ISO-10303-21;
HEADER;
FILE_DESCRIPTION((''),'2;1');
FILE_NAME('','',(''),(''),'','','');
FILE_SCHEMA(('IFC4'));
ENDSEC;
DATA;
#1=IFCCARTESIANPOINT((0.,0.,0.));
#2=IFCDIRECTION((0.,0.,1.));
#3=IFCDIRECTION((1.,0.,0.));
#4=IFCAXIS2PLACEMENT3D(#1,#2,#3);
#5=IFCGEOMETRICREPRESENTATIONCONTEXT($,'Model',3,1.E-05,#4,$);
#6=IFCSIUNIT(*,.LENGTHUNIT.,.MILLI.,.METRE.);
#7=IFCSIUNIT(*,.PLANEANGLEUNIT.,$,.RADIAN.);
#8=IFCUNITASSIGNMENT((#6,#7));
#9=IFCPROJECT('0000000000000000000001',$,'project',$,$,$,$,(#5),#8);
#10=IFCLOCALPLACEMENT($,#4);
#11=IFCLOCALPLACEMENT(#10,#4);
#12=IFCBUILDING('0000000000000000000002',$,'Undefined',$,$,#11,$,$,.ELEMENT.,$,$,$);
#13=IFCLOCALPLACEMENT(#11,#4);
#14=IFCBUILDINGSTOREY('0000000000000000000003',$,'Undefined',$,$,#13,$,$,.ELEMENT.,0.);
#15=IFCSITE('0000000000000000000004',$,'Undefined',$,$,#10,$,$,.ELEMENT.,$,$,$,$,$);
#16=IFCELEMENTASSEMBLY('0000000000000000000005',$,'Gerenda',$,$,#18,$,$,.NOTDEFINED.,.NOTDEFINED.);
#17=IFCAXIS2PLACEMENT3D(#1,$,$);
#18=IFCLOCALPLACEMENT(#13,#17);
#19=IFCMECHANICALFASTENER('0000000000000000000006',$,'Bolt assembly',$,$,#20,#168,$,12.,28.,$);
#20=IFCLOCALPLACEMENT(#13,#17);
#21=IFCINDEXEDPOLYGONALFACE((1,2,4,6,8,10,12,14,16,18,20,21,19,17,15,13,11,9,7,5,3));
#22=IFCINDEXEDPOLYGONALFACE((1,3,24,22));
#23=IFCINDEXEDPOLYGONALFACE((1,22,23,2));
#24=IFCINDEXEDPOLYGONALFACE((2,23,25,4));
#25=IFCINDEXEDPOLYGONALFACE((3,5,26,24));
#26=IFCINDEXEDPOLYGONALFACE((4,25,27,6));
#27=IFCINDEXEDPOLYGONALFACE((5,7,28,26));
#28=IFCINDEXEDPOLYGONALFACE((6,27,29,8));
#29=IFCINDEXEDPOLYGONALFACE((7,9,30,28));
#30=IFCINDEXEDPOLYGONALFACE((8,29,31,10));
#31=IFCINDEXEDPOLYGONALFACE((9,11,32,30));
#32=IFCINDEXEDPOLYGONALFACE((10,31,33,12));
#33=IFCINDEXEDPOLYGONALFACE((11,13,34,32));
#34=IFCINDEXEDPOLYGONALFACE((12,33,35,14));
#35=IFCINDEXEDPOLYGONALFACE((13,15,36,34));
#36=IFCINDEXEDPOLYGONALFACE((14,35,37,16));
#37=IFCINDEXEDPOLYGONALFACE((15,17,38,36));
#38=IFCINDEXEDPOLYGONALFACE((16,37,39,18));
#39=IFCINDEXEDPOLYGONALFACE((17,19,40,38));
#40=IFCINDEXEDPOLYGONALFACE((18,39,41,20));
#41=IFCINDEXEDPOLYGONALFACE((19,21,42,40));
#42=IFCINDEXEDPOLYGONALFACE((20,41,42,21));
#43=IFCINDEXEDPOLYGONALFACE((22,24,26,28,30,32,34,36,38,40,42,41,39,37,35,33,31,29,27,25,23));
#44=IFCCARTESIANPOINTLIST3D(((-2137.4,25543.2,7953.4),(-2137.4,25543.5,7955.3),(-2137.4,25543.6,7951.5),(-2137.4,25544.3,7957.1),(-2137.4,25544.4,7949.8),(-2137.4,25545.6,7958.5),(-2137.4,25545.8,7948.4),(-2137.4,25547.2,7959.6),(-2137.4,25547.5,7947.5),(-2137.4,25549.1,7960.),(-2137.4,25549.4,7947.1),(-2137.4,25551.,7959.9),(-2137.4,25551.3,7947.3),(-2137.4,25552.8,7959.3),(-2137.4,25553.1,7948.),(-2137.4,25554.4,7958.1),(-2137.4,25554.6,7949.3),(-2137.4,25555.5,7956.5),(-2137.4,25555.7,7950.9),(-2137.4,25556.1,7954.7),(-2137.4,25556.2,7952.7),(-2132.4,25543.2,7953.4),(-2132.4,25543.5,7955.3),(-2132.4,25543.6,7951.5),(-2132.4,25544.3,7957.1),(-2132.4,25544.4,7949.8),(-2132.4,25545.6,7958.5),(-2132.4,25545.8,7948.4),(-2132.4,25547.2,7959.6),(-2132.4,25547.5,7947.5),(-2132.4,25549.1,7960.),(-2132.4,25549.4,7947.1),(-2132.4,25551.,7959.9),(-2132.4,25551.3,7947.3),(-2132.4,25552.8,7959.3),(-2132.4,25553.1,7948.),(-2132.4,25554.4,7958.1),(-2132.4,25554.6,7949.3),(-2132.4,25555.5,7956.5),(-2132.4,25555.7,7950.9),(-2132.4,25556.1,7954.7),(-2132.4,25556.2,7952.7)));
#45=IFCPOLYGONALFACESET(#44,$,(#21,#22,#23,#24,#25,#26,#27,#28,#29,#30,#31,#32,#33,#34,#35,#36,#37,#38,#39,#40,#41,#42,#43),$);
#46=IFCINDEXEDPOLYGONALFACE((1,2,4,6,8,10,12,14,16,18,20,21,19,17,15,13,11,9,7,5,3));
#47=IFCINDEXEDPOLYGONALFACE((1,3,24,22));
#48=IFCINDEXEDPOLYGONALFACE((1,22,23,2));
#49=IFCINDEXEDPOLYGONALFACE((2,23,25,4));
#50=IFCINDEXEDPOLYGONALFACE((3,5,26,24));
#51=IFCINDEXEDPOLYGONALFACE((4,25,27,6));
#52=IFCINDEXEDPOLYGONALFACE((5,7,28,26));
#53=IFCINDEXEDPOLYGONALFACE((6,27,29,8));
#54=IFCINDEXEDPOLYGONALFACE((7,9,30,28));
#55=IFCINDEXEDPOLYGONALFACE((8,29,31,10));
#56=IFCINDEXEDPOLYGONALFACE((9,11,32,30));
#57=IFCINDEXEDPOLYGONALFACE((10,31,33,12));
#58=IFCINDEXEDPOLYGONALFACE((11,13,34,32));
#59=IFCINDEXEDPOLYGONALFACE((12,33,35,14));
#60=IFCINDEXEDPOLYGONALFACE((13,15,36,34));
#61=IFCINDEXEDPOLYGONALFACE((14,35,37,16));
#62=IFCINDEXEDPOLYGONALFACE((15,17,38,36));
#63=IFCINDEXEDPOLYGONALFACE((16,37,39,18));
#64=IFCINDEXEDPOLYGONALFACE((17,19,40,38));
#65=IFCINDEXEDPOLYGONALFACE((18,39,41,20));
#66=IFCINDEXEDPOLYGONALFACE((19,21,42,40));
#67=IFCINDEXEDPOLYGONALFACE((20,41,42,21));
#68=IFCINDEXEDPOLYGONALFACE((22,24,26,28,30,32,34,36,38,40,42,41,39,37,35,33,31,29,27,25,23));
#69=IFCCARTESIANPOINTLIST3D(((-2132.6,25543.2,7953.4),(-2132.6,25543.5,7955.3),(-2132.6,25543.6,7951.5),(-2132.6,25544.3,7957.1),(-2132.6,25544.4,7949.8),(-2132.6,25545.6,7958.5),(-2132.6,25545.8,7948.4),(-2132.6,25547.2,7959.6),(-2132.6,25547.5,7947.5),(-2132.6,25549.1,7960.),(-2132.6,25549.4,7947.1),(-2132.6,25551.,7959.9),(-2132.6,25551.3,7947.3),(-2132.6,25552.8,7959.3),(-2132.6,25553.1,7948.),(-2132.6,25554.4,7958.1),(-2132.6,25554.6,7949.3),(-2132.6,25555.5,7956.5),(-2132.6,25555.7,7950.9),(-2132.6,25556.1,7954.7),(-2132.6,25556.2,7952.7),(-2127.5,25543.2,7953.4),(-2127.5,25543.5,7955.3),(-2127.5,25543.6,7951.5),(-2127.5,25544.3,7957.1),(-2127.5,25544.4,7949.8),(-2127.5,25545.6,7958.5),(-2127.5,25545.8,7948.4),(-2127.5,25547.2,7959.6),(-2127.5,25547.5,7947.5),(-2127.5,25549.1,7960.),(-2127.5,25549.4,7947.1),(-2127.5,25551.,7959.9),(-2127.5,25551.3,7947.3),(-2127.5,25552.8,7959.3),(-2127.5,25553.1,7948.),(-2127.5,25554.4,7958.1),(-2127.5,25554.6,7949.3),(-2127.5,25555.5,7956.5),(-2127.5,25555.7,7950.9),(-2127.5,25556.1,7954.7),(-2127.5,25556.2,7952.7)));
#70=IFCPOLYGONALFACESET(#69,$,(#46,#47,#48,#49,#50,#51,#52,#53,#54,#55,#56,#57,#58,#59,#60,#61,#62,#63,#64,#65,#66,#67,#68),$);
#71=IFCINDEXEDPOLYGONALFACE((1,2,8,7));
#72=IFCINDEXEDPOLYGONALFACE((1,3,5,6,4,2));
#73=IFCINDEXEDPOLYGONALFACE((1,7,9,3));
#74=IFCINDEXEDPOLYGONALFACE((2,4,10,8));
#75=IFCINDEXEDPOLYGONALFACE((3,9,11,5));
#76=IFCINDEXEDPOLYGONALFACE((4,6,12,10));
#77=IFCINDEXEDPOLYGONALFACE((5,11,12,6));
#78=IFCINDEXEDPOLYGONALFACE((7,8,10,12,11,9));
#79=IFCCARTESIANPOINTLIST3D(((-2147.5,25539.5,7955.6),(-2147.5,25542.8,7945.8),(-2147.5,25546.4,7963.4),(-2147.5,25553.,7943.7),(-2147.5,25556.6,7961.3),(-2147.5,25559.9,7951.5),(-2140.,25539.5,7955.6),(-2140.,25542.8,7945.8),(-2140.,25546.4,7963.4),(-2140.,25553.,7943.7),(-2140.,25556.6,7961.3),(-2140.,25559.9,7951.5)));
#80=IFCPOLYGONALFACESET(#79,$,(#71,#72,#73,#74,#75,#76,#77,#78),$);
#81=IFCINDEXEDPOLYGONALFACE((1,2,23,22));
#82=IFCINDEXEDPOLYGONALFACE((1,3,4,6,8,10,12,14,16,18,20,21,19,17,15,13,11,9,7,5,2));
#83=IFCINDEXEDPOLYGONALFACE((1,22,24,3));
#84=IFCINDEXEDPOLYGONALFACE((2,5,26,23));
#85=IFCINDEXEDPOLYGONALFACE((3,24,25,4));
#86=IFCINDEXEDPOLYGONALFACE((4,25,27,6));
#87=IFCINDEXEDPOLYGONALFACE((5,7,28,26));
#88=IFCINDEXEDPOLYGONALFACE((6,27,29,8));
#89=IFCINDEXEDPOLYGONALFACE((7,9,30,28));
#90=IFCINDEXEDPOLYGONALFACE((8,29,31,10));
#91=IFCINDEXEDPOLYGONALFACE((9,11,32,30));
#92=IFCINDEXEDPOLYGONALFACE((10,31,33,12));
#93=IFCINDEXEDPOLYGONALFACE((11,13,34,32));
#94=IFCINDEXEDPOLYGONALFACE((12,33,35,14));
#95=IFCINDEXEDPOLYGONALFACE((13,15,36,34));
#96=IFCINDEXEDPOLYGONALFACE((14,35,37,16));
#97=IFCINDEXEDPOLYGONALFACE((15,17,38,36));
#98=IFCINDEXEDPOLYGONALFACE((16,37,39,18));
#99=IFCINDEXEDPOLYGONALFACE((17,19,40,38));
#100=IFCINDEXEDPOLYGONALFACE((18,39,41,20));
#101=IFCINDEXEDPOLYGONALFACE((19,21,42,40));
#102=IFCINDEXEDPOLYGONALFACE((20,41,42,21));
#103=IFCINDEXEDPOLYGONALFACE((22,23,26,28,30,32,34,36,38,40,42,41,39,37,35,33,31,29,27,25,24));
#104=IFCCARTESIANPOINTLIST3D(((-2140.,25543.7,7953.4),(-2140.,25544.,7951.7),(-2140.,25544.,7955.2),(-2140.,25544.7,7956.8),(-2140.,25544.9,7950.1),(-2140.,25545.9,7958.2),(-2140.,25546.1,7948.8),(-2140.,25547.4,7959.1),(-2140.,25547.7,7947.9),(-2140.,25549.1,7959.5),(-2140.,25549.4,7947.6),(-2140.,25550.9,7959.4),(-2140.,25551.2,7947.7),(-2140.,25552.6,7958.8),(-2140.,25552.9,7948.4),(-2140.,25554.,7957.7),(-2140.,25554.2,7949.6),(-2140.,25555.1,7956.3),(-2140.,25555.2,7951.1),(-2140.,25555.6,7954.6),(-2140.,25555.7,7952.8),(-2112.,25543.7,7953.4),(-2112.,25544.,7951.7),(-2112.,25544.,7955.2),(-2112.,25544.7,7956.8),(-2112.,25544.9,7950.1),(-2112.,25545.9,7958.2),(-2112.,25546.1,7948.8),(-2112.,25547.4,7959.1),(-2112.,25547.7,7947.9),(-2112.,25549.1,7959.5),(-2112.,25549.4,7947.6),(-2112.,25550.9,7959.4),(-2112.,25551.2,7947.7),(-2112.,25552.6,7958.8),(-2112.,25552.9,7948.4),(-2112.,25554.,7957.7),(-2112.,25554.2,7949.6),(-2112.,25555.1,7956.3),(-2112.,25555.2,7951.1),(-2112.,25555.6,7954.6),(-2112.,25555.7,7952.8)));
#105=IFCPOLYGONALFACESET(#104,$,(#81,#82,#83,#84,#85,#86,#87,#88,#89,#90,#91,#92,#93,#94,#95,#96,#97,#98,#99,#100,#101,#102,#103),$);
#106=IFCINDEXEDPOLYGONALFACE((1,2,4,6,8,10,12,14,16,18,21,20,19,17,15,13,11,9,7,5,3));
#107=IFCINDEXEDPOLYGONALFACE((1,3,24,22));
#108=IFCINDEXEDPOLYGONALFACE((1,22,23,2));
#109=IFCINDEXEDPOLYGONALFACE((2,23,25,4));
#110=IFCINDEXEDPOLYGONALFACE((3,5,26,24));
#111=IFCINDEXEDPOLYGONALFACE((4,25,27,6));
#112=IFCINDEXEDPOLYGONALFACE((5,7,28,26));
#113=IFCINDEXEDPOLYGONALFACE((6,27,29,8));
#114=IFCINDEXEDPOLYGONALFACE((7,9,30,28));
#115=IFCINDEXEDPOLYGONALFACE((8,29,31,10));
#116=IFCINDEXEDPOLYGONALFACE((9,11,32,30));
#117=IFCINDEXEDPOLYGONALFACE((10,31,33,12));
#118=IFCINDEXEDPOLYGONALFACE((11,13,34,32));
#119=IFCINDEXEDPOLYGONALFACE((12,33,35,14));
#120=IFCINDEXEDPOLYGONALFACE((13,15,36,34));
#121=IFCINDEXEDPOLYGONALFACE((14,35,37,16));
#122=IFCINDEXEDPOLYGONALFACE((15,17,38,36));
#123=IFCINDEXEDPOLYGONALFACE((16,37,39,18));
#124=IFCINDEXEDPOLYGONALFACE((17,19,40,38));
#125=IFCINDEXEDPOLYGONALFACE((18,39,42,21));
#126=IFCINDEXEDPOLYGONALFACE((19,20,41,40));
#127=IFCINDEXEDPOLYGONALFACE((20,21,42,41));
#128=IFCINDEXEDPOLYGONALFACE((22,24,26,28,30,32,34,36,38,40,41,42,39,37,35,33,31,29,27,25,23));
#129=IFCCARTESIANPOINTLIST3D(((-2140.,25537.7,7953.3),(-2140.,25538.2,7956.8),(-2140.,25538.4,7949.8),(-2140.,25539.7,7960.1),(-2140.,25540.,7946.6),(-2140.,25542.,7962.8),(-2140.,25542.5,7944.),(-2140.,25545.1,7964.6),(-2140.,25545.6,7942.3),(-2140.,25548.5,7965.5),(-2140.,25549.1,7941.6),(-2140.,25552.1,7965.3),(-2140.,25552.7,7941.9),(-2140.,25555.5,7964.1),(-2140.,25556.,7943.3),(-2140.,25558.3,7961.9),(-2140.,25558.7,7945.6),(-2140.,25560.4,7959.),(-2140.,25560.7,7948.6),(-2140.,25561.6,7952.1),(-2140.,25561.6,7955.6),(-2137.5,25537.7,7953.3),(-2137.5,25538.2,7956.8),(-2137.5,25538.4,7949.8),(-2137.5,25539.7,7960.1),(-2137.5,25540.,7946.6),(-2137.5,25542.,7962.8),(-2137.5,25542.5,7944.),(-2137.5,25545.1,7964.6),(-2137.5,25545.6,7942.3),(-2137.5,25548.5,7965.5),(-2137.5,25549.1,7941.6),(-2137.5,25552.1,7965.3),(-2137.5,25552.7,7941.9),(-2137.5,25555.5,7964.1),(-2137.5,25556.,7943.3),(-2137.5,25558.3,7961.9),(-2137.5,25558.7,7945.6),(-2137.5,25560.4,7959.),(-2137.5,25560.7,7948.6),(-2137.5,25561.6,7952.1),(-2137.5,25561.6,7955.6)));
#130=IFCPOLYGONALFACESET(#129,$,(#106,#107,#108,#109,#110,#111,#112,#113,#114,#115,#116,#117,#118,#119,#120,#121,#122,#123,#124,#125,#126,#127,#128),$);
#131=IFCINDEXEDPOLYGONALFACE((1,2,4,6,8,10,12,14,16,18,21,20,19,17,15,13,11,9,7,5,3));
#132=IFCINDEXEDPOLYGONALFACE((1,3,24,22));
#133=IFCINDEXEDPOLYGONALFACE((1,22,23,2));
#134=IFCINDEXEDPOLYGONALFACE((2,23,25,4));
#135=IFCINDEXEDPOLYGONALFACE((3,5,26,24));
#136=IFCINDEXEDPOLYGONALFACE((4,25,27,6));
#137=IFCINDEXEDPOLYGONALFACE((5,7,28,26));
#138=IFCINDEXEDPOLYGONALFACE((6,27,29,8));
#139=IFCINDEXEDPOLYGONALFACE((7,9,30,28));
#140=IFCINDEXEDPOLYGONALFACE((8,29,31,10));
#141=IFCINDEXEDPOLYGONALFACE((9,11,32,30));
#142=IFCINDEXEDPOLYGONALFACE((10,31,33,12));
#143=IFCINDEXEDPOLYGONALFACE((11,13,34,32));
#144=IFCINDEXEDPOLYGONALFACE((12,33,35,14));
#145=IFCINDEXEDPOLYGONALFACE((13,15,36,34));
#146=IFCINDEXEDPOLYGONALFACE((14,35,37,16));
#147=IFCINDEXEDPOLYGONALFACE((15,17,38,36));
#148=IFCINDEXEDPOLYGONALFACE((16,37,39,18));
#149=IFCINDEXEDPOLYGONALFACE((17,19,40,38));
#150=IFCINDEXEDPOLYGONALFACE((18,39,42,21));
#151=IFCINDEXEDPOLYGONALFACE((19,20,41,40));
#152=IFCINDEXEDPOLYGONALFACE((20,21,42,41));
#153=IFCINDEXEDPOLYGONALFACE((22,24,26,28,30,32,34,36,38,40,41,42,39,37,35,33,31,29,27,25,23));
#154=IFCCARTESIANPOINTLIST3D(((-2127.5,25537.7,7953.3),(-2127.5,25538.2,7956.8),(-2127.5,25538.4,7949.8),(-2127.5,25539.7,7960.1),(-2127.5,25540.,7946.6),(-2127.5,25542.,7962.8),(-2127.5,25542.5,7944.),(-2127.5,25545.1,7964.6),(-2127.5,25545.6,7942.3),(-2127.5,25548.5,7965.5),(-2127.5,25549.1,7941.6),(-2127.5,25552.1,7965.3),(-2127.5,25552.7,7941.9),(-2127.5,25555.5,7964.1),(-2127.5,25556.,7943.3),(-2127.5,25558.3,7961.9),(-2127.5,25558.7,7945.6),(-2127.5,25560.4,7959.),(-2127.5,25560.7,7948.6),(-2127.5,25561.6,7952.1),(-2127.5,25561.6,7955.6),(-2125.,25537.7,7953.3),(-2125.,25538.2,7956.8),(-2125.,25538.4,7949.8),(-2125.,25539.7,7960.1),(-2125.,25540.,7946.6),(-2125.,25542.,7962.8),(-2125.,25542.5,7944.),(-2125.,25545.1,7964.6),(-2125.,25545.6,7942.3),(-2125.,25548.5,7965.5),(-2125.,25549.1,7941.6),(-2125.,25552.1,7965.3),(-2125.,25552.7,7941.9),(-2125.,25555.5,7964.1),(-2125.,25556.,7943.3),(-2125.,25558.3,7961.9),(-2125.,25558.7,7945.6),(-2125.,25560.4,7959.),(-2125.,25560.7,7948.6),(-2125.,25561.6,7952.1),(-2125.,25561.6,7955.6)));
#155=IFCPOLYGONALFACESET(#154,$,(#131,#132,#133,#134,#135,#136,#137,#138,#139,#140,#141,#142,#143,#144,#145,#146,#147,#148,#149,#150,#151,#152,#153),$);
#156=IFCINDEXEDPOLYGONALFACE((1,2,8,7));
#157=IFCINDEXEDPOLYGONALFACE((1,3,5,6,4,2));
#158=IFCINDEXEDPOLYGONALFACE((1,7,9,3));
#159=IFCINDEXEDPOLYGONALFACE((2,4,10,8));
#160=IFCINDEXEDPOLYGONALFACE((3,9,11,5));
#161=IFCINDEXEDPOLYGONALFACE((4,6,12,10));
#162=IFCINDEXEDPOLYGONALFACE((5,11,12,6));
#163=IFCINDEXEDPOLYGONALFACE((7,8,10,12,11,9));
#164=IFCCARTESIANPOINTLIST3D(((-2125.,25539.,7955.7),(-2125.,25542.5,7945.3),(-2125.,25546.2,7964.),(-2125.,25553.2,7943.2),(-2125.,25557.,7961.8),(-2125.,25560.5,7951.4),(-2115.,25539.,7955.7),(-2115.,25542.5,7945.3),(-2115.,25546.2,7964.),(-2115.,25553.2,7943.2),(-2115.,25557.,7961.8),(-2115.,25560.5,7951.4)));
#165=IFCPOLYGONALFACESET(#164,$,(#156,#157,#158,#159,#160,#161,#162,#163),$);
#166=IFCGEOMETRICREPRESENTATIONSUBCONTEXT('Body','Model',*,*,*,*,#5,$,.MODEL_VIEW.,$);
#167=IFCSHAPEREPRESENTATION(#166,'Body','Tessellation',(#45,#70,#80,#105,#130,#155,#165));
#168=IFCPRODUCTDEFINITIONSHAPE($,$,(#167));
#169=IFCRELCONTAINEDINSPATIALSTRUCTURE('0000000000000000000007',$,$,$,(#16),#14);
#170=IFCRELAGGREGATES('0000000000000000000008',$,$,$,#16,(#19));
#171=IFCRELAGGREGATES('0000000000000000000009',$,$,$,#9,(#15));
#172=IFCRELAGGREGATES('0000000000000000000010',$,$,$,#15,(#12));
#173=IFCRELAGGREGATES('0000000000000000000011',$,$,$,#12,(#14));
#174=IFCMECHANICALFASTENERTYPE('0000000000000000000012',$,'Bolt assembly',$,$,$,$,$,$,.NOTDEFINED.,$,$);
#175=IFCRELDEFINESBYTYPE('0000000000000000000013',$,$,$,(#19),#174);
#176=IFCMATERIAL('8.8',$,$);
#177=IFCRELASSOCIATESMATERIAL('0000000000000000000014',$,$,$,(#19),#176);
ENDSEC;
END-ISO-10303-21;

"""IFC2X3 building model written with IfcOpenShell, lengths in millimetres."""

from ifc_helpers import new_model, si_unit, frame, origin_with_axes, origin_2d_with_axis, place, context, subcontext, project, spatial, polyline, circle, outline, extrude, source, transform, mapped, material, type_object, element, aggregate, save


model = new_model("IFC2X3")

# Units and contexts
model_context = context("Model", 3, precision=1e-05, world=origin_with_axes())
body_context = subcontext(model_context, "Body", "Model", "MODEL_VIEW")
ifc_project = project(units=[si_unit("LENGTHUNIT", "METRE", prefix="MILLI"), si_unit("PLANEANGLEUNIT", "RADIAN")], contexts=[model_context])

# Site, building, storey
site_placement = place(None, origin_with_axes())
site = spatial("IfcSite", under=ifc_project, at=site_placement, Name="Undefined", CompositionType="ELEMENT")
building_placement = place(site_placement, origin_with_axes())
building = spatial("IfcBuilding", under=site, at=building_placement, Name="Undefined", CompositionType="ELEMENT")
storey_placement = place(building_placement, origin_with_axes())
storey = spatial("IfcBuildingStorey", under=building, at=storey_placement, Name="Undefined", CompositionType="ELEMENT", Elevation=0.0)

# Element assembly
assembly_1_placement = place(storey_placement, origin_with_axes())
assembly_1 = element("IfcElementAssembly", 1, at=assembly_1_placement, inside=storey, Name="Gerenda", AssemblyPlace="NOTDEFINED", PredefinedType="NOTDEFINED")

# Mechanical fastener
ifc_material_1 = material(Name="8.8")
mechanical_fastener_type = type_object("IfcMechanicalFastenerType", Name="Bolt assembly")
shared_shape_1 = source(origin_with_axes(), body_context, "Body", "SweptSolid", [
    extrude(circle(Radius=6.5, at=origin_2d_with_axis()), frame((0.0, -7.4, 0.0), z_axis=(0.0, 1.0, 0.0), x_axis=(1.0, 0.0, 0.0)), (0.0, 0.0, 1.0), 5.0),
    extrude(circle(Radius=6.5, at=origin_2d_with_axis()), frame((0.0, -2.6, 0.0), z_axis=(0.0, 1.0, 0.0), x_axis=(1.0, 0.0, 0.0)), (0.0, 0.0, 1.0), 5.1),
    extrude(outline(polyline([(9.0, -5.2), (9.0, 5.2), (0.0, 10.4), (-9.0, 5.2), (-9.0, -5.2), (0.0, -10.4), (9.0, -5.2)])), frame((0.0, -17.5, 0.0), z_axis=(0.0, 1.0, 0.0), x_axis=(1.0, 0.0, 0.0)), (0.0, 0.0, 1.0), 7.5),
    extrude(circle(Radius=6.0, at=origin_2d_with_axis()), frame((0.0, -10.0, 0.0), z_axis=(0.0, 1.0, 0.0), x_axis=(1.0, 0.0, 0.0)), (0.0, 0.0, 1.0), 28.0),
    extrude(circle(Radius=12.0, at=origin_2d_with_axis()), frame((0.0, -10.0, 0.0), z_axis=(0.0, 1.0, 0.0), x_axis=(1.0, 0.0, 0.0)), (0.0, 0.0, 1.0), 2.5),
    extrude(circle(Radius=12.0, at=origin_2d_with_axis()), frame((0.0, 2.5, 0.0), z_axis=(0.0, 1.0, 0.0), x_axis=(1.0, 0.0, 0.0)), (0.0, 0.0, 1.0), 2.5),
    extrude(outline(polyline([(9.5, -5.5), (9.5, 5.5), (0.0, 11.0), (-9.5, 5.5), (-9.5, -5.5), (0.0, -11.0), (9.5, -5.5)])), frame((0.0, 5.0, 0.0), z_axis=(0.0, 1.0, 0.0), x_axis=(1.0, 0.0, 0.0)), (0.0, 0.0, 1.0), 10.0),
])
mechanical_fastener_1_placement = place(assembly_1_placement, frame((-2130.0, 25549.7, 7953.6), z_axis=(0.000003, -0.662403, -0.749147), x_axis=(0.000003, 0.749147, -0.662403)))
mechanical_fastener_1 = element("IfcMechanicalFastener", 2, at=mechanical_fastener_1_placement, type_object=mechanical_fastener_type, material=ifc_material_1, Name="Bolt assembly", NominalDiameter=12.0, NominalLength=28.0, context=body_context, shape_type="MappedRepresentation", body=[
    mapped(shared_shape_1, transform((0.0, 0.0, 0.0))),
])
aggregate(assembly_1, [mechanical_fastener_1])

save(model, "model.ifc")
